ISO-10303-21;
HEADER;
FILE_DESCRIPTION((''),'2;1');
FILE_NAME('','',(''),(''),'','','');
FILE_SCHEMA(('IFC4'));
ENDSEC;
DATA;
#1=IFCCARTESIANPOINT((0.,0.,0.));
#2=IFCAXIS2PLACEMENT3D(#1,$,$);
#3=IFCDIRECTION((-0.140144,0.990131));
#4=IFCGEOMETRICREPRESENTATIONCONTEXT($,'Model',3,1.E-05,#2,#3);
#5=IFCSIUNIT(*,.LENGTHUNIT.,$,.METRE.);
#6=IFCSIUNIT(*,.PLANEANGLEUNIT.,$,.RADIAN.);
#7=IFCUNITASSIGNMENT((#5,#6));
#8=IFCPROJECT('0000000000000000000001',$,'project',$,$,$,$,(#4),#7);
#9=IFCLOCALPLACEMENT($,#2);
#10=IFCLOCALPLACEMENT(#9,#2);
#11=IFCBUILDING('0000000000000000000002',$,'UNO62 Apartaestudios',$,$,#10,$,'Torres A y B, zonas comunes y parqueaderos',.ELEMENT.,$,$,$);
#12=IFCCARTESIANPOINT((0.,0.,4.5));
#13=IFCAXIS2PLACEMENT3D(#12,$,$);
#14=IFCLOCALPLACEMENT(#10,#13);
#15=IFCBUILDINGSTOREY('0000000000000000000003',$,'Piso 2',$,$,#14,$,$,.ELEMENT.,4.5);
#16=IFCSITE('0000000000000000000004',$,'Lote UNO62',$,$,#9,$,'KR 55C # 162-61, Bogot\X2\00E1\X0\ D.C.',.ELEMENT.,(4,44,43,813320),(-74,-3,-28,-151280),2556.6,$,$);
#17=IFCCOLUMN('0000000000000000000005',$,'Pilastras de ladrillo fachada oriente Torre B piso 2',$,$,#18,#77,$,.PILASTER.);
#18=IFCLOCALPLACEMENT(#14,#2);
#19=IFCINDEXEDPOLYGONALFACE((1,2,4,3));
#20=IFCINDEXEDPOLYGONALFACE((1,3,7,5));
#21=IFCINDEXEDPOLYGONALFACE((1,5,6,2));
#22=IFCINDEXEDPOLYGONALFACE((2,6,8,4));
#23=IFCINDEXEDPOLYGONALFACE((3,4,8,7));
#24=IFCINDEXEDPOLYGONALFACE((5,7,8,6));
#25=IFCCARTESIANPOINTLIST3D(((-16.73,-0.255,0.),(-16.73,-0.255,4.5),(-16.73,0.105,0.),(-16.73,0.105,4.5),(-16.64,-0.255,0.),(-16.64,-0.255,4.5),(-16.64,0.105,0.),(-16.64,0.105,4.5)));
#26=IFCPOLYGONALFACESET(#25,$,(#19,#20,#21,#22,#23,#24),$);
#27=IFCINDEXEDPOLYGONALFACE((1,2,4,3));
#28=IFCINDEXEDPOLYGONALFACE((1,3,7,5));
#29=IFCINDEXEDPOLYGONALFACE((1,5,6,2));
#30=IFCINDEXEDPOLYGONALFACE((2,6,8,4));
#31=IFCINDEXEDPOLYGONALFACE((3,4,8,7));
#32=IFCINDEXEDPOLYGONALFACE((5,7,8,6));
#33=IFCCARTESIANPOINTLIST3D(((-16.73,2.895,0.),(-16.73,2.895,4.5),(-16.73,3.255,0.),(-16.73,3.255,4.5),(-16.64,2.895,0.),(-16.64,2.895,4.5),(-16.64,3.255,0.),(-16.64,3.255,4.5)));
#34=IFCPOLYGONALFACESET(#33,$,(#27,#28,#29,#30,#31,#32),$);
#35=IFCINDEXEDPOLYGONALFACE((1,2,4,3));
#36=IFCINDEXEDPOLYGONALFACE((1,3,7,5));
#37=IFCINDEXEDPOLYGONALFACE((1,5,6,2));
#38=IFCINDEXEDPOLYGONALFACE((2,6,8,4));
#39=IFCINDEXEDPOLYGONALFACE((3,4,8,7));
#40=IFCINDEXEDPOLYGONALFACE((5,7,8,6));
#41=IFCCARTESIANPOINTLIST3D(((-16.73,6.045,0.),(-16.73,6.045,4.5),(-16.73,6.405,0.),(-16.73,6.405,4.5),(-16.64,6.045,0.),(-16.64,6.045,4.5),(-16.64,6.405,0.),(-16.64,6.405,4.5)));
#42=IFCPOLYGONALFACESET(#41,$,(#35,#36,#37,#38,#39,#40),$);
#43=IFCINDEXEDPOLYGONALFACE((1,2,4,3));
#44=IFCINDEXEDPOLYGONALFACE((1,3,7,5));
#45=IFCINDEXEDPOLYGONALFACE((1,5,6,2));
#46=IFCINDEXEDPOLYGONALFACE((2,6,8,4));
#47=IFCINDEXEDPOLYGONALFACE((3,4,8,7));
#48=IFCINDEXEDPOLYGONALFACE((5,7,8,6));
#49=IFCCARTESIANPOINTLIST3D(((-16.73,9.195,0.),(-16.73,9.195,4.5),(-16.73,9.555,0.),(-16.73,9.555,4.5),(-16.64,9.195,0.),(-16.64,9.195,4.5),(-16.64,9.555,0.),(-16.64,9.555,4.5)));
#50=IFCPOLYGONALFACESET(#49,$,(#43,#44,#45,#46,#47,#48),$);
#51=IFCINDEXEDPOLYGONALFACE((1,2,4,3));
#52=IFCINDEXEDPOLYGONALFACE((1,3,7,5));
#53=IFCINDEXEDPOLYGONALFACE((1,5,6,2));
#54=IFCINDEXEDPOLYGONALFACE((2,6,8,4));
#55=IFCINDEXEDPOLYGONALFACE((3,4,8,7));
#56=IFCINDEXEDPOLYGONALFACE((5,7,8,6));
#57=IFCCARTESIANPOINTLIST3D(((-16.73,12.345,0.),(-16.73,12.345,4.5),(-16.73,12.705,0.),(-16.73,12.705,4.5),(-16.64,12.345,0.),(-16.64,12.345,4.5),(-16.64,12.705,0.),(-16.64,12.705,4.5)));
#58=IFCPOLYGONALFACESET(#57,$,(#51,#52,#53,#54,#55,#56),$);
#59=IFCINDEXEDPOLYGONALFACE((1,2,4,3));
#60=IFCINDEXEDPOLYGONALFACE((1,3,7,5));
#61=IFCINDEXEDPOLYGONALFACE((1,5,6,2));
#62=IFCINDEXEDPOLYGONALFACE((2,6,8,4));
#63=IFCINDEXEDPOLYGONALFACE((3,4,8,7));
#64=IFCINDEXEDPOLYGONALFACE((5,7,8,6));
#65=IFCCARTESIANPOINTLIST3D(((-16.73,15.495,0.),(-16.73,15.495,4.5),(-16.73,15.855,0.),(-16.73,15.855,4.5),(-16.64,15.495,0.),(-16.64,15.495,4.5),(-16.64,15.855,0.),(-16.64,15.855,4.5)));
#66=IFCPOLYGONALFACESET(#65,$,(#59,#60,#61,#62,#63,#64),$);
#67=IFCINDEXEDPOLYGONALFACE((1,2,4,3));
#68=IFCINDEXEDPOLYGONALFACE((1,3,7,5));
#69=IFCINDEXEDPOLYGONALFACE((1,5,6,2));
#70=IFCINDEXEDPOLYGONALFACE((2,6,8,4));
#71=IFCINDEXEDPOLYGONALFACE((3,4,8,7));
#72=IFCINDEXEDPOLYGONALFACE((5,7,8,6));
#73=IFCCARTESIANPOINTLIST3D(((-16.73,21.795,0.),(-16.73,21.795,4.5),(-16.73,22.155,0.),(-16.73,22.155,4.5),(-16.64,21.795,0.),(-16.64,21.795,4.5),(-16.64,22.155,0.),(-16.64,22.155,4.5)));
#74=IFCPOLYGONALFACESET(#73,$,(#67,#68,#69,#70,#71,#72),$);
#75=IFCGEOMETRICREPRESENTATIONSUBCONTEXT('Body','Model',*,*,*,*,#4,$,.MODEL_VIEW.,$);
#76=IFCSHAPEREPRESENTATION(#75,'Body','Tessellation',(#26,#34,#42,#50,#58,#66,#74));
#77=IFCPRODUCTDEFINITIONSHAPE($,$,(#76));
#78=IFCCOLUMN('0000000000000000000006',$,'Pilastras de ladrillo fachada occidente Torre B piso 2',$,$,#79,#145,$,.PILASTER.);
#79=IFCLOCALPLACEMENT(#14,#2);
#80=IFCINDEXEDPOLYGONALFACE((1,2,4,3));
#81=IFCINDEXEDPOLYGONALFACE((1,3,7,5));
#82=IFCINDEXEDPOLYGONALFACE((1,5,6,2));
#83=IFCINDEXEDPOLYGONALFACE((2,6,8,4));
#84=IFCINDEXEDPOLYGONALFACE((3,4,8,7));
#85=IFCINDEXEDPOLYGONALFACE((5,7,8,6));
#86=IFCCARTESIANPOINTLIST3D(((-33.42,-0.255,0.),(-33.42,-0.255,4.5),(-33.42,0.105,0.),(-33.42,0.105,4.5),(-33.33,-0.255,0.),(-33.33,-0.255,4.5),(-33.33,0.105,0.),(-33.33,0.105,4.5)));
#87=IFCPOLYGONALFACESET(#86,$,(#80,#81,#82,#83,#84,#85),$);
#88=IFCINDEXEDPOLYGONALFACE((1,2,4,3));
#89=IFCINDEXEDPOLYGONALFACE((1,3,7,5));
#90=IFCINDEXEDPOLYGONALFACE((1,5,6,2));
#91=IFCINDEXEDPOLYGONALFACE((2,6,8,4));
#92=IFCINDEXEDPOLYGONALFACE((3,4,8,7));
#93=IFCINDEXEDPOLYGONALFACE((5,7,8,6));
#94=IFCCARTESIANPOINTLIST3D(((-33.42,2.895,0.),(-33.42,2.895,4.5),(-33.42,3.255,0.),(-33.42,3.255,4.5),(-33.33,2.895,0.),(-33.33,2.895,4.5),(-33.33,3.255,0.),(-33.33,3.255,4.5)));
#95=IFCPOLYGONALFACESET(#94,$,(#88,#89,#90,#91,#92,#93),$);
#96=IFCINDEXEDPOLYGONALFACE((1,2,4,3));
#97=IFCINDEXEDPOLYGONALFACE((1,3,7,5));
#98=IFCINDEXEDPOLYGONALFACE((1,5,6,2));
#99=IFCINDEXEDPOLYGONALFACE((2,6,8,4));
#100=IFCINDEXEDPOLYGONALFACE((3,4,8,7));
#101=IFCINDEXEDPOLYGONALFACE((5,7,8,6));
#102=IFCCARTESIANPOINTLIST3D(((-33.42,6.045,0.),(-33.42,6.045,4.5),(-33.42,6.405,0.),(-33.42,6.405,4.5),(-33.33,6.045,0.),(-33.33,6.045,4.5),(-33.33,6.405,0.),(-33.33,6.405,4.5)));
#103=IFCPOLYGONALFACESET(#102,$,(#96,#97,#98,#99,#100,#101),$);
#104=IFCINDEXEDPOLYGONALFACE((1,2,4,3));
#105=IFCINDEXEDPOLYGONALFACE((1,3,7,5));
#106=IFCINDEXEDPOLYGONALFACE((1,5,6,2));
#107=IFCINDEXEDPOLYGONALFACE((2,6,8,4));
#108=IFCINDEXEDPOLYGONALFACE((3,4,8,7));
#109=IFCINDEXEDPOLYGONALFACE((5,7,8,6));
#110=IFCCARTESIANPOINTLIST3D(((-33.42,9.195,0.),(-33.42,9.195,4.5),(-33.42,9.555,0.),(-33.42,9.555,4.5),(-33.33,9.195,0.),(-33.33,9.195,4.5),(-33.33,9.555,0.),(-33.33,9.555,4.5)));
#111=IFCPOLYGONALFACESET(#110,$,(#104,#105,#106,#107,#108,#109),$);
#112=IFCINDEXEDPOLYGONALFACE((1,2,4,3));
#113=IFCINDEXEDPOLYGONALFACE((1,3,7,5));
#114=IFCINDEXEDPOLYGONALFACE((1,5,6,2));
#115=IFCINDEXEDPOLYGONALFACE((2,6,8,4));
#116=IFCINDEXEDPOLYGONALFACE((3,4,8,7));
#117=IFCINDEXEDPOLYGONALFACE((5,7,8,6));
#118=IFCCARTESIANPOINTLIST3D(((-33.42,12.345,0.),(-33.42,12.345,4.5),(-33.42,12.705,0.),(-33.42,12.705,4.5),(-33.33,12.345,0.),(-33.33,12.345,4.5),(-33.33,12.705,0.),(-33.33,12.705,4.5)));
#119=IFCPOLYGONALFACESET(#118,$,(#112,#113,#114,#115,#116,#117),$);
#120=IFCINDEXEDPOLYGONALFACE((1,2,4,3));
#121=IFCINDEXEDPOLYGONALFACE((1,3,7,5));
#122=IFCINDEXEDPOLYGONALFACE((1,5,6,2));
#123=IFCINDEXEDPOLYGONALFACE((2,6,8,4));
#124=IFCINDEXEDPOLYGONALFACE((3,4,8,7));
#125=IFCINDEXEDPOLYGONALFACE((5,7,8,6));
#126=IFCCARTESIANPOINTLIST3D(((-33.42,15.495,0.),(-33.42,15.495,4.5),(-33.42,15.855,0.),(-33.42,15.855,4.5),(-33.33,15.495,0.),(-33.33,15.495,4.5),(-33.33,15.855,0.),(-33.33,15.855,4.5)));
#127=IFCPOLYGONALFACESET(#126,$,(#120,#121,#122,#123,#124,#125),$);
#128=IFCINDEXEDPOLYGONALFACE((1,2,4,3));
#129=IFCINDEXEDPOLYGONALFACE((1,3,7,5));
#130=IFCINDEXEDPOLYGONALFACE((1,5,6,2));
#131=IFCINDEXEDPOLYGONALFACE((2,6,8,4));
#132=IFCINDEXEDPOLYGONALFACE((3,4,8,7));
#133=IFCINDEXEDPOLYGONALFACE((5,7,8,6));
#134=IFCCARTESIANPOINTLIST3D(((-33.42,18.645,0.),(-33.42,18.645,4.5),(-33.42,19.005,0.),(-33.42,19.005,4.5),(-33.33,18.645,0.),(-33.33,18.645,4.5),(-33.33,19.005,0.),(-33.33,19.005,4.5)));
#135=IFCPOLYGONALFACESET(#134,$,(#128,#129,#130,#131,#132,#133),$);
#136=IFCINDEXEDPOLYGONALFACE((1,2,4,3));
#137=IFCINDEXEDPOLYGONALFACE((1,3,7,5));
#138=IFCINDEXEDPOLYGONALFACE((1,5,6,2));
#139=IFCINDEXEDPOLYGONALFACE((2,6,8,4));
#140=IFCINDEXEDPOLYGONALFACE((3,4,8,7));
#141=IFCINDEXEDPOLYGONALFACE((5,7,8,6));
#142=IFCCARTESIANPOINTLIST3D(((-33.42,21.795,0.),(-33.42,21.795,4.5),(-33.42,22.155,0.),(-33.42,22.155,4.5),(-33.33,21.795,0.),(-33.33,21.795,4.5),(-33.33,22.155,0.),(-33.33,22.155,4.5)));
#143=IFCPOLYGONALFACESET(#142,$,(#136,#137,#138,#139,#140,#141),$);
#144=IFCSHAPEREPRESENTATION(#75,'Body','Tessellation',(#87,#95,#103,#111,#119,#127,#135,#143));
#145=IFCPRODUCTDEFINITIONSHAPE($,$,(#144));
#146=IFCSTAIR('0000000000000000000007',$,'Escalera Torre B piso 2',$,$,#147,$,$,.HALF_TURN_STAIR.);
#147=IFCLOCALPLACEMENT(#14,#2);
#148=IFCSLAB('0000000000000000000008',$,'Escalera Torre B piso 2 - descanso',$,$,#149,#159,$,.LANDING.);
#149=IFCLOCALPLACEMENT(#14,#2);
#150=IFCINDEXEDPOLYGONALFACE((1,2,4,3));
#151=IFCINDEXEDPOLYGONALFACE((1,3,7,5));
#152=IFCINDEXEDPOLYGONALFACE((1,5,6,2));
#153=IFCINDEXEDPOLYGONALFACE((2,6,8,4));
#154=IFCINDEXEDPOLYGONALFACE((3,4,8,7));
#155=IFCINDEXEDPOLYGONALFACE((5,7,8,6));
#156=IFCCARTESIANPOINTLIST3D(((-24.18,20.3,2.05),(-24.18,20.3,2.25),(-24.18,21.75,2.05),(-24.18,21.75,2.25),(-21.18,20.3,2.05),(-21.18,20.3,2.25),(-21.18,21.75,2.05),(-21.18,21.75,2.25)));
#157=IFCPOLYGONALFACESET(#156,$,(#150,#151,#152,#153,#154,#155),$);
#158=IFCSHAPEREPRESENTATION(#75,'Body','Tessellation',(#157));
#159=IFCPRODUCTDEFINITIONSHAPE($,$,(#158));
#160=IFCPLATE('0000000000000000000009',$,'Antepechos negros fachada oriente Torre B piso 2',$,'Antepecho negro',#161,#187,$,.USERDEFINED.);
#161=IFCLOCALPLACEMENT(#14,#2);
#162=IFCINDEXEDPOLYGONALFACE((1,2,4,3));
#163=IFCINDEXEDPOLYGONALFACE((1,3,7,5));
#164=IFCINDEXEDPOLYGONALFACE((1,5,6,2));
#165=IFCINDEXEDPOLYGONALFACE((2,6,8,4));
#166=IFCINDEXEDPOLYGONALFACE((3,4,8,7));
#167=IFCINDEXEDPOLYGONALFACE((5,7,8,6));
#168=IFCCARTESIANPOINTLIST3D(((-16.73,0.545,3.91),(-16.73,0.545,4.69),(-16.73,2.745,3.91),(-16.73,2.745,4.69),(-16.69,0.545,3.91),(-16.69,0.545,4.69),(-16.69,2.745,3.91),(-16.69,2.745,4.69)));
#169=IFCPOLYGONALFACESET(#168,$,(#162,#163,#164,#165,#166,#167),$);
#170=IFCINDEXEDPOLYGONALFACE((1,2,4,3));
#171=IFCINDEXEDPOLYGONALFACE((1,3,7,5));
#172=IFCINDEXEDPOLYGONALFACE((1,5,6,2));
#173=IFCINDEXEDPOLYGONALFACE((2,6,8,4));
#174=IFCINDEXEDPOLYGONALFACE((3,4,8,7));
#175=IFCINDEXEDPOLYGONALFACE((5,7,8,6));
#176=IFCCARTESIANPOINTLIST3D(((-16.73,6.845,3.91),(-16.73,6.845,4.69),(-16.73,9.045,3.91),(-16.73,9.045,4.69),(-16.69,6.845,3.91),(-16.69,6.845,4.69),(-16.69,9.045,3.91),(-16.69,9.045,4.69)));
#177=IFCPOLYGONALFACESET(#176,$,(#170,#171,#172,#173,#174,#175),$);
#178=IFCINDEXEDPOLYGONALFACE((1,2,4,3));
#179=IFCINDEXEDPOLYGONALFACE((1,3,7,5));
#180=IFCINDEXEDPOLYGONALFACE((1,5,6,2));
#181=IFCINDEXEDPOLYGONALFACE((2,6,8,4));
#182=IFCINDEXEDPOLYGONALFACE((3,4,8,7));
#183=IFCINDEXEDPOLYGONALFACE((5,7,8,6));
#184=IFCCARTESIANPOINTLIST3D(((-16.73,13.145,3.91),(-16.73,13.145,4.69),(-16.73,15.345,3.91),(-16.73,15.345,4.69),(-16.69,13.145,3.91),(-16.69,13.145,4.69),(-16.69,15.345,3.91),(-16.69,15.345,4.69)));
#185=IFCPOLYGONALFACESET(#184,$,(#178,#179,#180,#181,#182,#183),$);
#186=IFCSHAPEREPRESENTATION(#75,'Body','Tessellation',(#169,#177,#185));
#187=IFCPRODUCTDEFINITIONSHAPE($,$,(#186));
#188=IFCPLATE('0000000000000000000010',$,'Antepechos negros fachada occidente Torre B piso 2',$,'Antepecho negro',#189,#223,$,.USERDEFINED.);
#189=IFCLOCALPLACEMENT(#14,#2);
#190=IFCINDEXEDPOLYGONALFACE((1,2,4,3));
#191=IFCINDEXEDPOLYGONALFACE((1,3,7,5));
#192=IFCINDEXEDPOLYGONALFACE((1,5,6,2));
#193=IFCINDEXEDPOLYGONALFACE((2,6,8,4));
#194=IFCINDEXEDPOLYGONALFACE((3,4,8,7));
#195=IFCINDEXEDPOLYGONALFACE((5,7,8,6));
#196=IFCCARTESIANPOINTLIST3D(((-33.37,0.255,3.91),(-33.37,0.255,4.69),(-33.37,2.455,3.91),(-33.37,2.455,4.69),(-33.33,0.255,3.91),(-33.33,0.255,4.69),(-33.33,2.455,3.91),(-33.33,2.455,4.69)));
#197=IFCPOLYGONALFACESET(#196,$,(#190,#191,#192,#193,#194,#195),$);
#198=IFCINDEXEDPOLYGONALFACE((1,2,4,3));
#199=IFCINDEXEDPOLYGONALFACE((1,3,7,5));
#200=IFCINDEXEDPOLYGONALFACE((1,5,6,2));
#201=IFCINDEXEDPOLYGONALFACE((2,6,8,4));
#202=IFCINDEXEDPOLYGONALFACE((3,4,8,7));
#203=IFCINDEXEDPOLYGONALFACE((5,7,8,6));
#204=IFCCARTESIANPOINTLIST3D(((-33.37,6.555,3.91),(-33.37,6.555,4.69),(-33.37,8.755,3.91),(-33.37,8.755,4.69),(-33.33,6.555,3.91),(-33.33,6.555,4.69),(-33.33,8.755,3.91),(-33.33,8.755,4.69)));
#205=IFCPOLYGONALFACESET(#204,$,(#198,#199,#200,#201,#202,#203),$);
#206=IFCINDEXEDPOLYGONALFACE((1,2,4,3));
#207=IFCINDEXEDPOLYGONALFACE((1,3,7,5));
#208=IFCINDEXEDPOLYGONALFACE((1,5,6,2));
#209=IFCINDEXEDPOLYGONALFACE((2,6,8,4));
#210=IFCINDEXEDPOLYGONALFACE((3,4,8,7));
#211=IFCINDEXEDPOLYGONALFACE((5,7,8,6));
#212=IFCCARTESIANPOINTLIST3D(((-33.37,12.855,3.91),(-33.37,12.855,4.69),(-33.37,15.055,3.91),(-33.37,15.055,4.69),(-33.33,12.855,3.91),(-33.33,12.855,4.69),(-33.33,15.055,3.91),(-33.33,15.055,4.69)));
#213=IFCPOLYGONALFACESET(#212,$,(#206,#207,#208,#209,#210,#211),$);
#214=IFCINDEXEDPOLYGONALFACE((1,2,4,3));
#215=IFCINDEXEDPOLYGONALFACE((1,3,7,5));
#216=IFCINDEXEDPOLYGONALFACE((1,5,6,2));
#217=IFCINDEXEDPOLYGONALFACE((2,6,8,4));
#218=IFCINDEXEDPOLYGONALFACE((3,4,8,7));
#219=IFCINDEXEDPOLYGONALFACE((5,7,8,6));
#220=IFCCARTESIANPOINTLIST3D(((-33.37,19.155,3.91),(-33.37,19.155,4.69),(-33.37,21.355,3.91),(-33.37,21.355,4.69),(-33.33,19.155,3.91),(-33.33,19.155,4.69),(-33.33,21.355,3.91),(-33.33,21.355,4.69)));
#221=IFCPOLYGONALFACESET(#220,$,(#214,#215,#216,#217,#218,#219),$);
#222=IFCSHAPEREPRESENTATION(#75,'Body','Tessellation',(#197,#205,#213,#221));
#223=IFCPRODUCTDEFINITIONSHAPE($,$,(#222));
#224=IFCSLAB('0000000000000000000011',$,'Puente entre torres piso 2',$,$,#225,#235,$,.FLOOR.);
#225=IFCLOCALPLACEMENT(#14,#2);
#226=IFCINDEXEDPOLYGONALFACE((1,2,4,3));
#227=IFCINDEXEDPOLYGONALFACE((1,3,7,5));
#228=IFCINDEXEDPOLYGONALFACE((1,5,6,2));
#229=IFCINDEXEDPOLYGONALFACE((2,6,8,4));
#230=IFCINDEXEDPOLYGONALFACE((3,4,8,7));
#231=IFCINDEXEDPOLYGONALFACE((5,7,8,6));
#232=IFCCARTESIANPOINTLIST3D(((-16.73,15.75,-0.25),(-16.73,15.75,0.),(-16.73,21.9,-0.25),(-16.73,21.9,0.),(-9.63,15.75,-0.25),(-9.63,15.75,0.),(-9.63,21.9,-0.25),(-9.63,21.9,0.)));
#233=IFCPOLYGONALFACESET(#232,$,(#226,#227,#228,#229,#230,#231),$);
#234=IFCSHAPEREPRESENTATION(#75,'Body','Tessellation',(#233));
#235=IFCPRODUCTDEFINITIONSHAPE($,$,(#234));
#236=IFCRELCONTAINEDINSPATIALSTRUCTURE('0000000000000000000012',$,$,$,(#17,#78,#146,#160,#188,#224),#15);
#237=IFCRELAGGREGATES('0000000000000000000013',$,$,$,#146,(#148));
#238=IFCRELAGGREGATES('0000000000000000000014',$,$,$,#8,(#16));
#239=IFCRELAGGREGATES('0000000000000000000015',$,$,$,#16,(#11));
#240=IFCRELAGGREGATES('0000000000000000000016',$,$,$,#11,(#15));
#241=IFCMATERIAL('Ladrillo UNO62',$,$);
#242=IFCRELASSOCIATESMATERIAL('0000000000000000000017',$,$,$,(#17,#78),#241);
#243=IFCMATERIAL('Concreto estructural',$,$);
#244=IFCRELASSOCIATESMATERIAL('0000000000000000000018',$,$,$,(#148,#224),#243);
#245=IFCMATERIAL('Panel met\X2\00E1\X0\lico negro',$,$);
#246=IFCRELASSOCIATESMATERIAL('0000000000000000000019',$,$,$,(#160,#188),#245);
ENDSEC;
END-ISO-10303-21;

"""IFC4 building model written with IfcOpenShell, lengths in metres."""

from ifc_helpers import new_model, si_unit, direction, frame, frame_2d, origin, place, context, subcontext, project, spatial, rectangle, extrude, material, element, aggregate, save


model = new_model("IFC4")

# Units and contexts
model_context = context("Model", 3, precision=1e-05, world=origin(), true_north=direction((-0.140144, 0.990131)))
body_context = subcontext(model_context, "Body", "Model", "MODEL_VIEW")
ifc_project = project(units=[si_unit("LENGTHUNIT", "METRE"), si_unit("PLANEANGLEUNIT", "RADIAN")], contexts=[model_context])

# Site, building, storey
site_placement = place(None, origin())
site = spatial("IfcSite", under=ifc_project, at=site_placement, Name="Lote UNO62", LongName="KR 55C # 162-61, Bogotá D.C.", CompositionType="ELEMENT", RefLatitude=(4, 44, 43, 813320), RefLongitude=(-74, -3, -28, -151280), RefElevation=2556.6)
building_placement = place(site_placement, origin())
building = spatial("IfcBuilding", under=site, at=building_placement, Name="UNO62 Apartaestudios", LongName="Torres A y B, zonas comunes y parqueaderos", CompositionType="ELEMENT")
storey_placement = place(building_placement, frame((0.0, 0.0, 4.5)))
storey = spatial("IfcBuildingStorey", under=building, at=storey_placement, Name="Piso 2", CompositionType="ELEMENT", Elevation=4.5)

# Columns
ifc_material_1 = material(Name="Ladrillo UNO62")
column_1_placement = place(storey_placement, origin())
element("IfcColumn", 1, at=column_1_placement, inside=storey, material=ifc_material_1, Name="Pilastras de ladrillo fachada oriente Torre B piso 2", PredefinedType="PILASTER", context=body_context, shape_type="SweptSolid", body=[
    extrude(rectangle(XDim=0.09, YDim=0.36, at=frame_2d((-16.685, -0.075))), origin(), (0.0, 0.0, 1.0), 4.5),
    extrude(rectangle(XDim=0.09, YDim=0.36, at=frame_2d((-16.685, 3.075))), origin(), (0.0, 0.0, 1.0), 4.5),
    extrude(rectangle(XDim=0.09, YDim=0.36, at=frame_2d((-16.685, 6.225))), origin(), (0.0, 0.0, 1.0), 4.5),
    extrude(rectangle(XDim=0.09, YDim=0.36, at=frame_2d((-16.685, 9.375))), origin(), (0.0, 0.0, 1.0), 4.5),
    extrude(rectangle(XDim=0.09, YDim=0.36, at=frame_2d((-16.685, 12.525))), origin(), (0.0, 0.0, 1.0), 4.5),
    extrude(rectangle(XDim=0.09, YDim=0.36, at=frame_2d((-16.685, 15.675))), origin(), (0.0, 0.0, 1.0), 4.5),
    extrude(rectangle(XDim=0.09, YDim=0.36, at=frame_2d((-16.685, 21.975))), origin(), (0.0, 0.0, 1.0), 4.5),
])
column_2_placement = place(storey_placement, origin())
element("IfcColumn", 2, at=column_2_placement, inside=storey, material=ifc_material_1, Name="Pilastras de ladrillo fachada occidente Torre B piso 2", PredefinedType="PILASTER", context=body_context, shape_type="SweptSolid", body=[
    extrude(rectangle(XDim=0.09, YDim=0.36, at=frame_2d((-33.375, -0.075))), origin(), (0.0, 0.0, 1.0), 4.5),
    extrude(rectangle(XDim=0.09, YDim=0.36, at=frame_2d((-33.375, 3.075))), origin(), (0.0, 0.0, 1.0), 4.5),
    extrude(rectangle(XDim=0.09, YDim=0.36, at=frame_2d((-33.375, 6.225))), origin(), (0.0, 0.0, 1.0), 4.5),
    extrude(rectangle(XDim=0.09, YDim=0.36, at=frame_2d((-33.375, 9.375))), origin(), (0.0, 0.0, 1.0), 4.5),
    extrude(rectangle(XDim=0.09, YDim=0.36, at=frame_2d((-33.375, 12.525))), origin(), (0.0, 0.0, 1.0), 4.5),
    extrude(rectangle(XDim=0.09, YDim=0.36, at=frame_2d((-33.375, 15.675))), origin(), (0.0, 0.0, 1.0), 4.5),
    extrude(rectangle(XDim=0.09, YDim=0.36, at=frame_2d((-33.375, 18.825))), origin(), (0.0, 0.0, 1.0), 4.5),
    extrude(rectangle(XDim=0.09, YDim=0.36, at=frame_2d((-33.375, 21.975))), origin(), (0.0, 0.0, 1.0), 4.5),
])

# Stair, slab
stair_placement = place(storey_placement, origin())
stair = element("IfcStair", 3, at=stair_placement, inside=storey, Name="Escalera Torre B piso 2", PredefinedType="HALF_TURN_STAIR")
ifc_material_2 = material(Name="Concreto estructural")
slab_1_placement = place(storey_placement, origin())
slab_1 = element("IfcSlab", 4, at=slab_1_placement, material=ifc_material_2, Name="Escalera Torre B piso 2 - descanso", PredefinedType="LANDING", context=body_context, shape_type="SweptSolid", body=[
    extrude(rectangle(XDim=3.0, YDim=1.45, at=frame_2d((-22.68, 21.025))), frame((0.0, 0.0, 2.05)), (0.0, 0.0, 1.0), 0.2),
])

# Plates
ifc_material_3 = material(Name="Panel metálico negro")
plate_1_placement = place(storey_placement, origin())
element("IfcPlate", 5, at=plate_1_placement, inside=storey, material=ifc_material_3, Name="Antepechos negros fachada oriente Torre B piso 2", ObjectType="Antepecho negro", PredefinedType="USERDEFINED", context=body_context, shape_type="SweptSolid", body=[
    extrude(rectangle(XDim=0.04, YDim=2.2, at=frame_2d((-16.71, 1.645))), frame((0.0, 0.0, 3.91)), (0.0, 0.0, 1.0), 0.78),
    extrude(rectangle(XDim=0.04, YDim=2.2, at=frame_2d((-16.71, 7.945))), frame((0.0, 0.0, 3.91)), (0.0, 0.0, 1.0), 0.78),
    extrude(rectangle(XDim=0.04, YDim=2.2, at=frame_2d((-16.71, 14.245))), frame((0.0, 0.0, 3.91)), (0.0, 0.0, 1.0), 0.78),
])
plate_2_placement = place(storey_placement, origin())
element("IfcPlate", 6, at=plate_2_placement, inside=storey, material=ifc_material_3, Name="Antepechos negros fachada occidente Torre B piso 2", ObjectType="Antepecho negro", PredefinedType="USERDEFINED", context=body_context, shape_type="SweptSolid", body=[
    extrude(rectangle(XDim=0.04, YDim=2.2, at=frame_2d((-33.35, 1.355))), frame((0.0, 0.0, 3.91)), (0.0, 0.0, 1.0), 0.78),
    extrude(rectangle(XDim=0.04, YDim=2.2, at=frame_2d((-33.35, 7.655))), frame((0.0, 0.0, 3.91)), (0.0, 0.0, 1.0), 0.78),
    extrude(rectangle(XDim=0.04, YDim=2.2, at=frame_2d((-33.35, 13.955))), frame((0.0, 0.0, 3.91)), (0.0, 0.0, 1.0), 0.78),
    extrude(rectangle(XDim=0.04, YDim=2.2, at=frame_2d((-33.35, 20.255))), frame((0.0, 0.0, 3.91)), (0.0, 0.0, 1.0), 0.78),
])

# Slab
slab_2_placement = place(storey_placement, origin())
element("IfcSlab", 7, at=slab_2_placement, inside=storey, material=ifc_material_2, Name="Puente entre torres piso 2", PredefinedType="FLOOR", context=body_context, shape_type="SweptSolid", body=[
    extrude(rectangle(XDim=7.1, YDim=6.15, at=frame_2d((-13.18, 18.825))), frame((0.0, 0.0, -0.25)), (0.0, 0.0, 1.0), 0.25),
])

aggregate(stair, [slab_1])

save(model, "model.ifc")
